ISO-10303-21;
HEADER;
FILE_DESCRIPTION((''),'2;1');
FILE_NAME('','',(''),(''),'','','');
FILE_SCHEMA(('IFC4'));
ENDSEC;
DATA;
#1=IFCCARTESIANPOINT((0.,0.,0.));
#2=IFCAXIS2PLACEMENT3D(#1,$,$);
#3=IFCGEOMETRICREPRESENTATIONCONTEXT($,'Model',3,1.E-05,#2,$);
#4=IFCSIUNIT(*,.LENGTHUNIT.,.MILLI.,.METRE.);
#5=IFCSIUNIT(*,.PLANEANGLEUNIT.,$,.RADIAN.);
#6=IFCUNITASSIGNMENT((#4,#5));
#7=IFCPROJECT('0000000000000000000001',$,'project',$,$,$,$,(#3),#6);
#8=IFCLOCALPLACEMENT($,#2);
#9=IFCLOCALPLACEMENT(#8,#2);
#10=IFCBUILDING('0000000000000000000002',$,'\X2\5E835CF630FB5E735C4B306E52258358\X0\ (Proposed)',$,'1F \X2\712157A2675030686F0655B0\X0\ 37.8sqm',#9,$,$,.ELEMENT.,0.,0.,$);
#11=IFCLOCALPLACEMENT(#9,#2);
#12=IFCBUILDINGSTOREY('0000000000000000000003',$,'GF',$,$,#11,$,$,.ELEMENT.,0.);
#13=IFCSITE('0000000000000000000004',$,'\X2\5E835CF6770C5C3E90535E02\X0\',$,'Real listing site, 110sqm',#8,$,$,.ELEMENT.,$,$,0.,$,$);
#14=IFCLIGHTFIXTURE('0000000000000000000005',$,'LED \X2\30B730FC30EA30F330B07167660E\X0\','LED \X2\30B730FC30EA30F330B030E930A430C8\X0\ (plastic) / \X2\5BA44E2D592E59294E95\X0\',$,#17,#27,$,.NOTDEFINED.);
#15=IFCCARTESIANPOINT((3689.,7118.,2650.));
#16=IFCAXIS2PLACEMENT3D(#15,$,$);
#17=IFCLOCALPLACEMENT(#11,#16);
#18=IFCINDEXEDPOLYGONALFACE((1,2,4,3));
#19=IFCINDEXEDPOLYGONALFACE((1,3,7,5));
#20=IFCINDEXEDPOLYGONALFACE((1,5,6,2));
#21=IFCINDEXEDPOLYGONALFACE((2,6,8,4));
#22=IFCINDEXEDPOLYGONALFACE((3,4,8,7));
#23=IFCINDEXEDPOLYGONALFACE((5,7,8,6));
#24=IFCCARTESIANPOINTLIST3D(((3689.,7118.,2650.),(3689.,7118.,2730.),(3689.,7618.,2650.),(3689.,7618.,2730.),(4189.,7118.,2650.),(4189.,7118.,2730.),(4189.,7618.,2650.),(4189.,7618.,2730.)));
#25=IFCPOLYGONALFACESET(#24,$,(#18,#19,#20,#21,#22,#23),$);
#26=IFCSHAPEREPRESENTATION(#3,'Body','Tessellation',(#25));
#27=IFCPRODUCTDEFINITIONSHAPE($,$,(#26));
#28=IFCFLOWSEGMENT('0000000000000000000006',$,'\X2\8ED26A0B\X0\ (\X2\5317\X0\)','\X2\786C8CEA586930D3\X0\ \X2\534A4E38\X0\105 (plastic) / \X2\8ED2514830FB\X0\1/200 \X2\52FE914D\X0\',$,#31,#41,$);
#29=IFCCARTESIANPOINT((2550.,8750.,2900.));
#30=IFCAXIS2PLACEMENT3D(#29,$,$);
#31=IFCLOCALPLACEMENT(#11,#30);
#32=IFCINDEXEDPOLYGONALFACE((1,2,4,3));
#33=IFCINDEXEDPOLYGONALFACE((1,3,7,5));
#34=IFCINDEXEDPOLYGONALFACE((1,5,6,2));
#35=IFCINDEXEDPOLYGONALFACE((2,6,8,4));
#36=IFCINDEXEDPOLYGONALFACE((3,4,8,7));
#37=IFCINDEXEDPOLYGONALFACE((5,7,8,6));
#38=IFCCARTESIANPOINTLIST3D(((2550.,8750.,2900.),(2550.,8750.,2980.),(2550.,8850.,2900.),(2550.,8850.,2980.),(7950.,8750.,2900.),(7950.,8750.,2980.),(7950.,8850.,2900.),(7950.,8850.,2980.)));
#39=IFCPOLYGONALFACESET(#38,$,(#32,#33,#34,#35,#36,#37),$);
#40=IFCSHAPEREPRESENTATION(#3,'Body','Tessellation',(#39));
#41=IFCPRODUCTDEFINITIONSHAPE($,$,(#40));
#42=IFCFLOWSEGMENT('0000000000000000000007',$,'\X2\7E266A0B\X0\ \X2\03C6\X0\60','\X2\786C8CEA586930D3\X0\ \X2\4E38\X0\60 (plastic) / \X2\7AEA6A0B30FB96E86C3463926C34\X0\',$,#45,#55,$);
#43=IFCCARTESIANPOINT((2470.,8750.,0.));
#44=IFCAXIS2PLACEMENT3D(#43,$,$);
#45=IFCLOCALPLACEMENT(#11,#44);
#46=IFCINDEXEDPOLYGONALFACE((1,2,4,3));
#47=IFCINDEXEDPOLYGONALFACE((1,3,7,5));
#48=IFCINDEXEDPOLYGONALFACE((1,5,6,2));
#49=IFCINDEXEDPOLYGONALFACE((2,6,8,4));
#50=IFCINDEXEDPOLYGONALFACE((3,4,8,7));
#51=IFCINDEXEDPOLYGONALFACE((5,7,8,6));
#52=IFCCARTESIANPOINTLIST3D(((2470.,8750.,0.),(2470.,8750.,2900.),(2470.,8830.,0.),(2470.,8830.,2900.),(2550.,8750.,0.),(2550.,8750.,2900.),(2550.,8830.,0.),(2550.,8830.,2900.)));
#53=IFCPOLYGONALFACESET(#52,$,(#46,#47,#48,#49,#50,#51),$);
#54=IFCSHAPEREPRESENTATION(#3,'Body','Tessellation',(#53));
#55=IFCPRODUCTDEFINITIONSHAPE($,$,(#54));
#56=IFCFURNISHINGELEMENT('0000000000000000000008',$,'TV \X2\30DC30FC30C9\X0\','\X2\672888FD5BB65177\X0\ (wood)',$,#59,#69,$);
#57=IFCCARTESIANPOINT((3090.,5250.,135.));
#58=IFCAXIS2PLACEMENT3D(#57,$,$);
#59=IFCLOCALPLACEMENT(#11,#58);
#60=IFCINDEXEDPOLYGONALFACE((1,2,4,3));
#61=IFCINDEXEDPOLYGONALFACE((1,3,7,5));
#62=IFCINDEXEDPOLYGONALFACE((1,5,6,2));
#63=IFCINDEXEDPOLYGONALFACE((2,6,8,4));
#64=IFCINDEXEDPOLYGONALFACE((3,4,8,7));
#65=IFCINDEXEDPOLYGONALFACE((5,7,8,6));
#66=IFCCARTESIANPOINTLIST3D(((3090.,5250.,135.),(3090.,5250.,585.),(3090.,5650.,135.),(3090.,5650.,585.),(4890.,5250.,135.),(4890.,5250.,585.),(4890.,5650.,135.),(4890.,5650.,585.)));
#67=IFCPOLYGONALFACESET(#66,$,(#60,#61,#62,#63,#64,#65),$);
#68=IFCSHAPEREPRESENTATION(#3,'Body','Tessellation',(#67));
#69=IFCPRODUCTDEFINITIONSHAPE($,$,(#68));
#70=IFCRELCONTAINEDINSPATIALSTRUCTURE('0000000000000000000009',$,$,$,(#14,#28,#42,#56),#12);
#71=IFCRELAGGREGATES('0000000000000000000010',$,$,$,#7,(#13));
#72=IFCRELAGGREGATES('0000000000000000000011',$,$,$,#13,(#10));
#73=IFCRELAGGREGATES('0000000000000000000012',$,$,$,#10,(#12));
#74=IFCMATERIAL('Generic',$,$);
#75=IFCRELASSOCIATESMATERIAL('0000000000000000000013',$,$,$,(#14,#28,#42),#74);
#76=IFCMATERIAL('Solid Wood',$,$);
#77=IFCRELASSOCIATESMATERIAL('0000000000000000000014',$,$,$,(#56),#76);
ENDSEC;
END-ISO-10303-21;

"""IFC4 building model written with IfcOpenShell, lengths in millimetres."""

from ifc_helpers import new_model, si_unit, frame, frame_2d, origin, place, context, project, spatial, rectangle, extrude, material, element, save


model = new_model("IFC4")

# Units and contexts
model_context = context("Model", 3, precision=1e-05, world=origin())
ifc_project = project(units=[si_unit("LENGTHUNIT", "METRE", prefix="MILLI"), si_unit("PLANEANGLEUNIT", "RADIAN")], contexts=[model_context])

# Site, building, storey
site_placement = place(None, origin())
site = spatial("IfcSite", under=ifc_project, at=site_placement, Name="広島県尾道市", ObjectType="Real listing site, 110sqm", CompositionType="ELEMENT", RefElevation=0.0)
building_placement = place(site_placement, origin())
building = spatial("IfcBuilding", under=site, at=building_placement, Name="広島・平屋の別荘 (Proposed)", ObjectType="1F 無垢材と漆喰 37.8sqm", CompositionType="ELEMENT", ElevationOfRefHeight=0.0, ElevationOfTerrain=0.0)
storey_placement = place(building_placement, origin())
storey = spatial("IfcBuildingStorey", under=building, at=storey_placement, Name="GF", CompositionType="ELEMENT", Elevation=0.0)

# Shared definitions
ifc_material_1 = material(Name="Solid Wood")

# Shared definitions
ifc_material_2 = material(Name="Generic")

# Light fixture
light_fixture_placement = place(storey_placement, frame((3689.0, 7118.0, 2650.0)))
element("IfcLightFixture", 1, at=light_fixture_placement, inside=storey, material=ifc_material_2, Name="LED シーリング照明", Description="LED シーリングライト (plastic) / 室中央天井", PredefinedType="NOTDEFINED", context=model_context, shape_type="SweptSolid", body=[
    extrude(rectangle(XDim=500.0, YDim=500.0, at=frame_2d((250.0, 250.0))), frame((3689.0, 7118.0, 2650.0)), (0.0, 0.0, 1.0), 80.0),
])

# Flow segments
flow_segment_1_placement = place(storey_placement, frame((2550.0, 8750.0, 2900.0)))
element("IfcFlowSegment", 2, at=flow_segment_1_placement, inside=storey, material=ifc_material_2, Name="軒樋 (北)", Description="硬質塩ビ 半丸105 (plastic) / 軒先・1/200 勾配", context=model_context, shape_type="SweptSolid", body=[
    extrude(rectangle(XDim=5400.0, YDim=100.0, at=frame_2d((2700.0, 50.0))), frame((2550.0, 8750.0, 2900.0)), (0.0, 0.0, 1.0), 80.0),
])
flow_segment_2_placement = place(storey_placement, frame((2470.0, 8750.0, 0.0)))
element("IfcFlowSegment", 3, at=flow_segment_2_placement, inside=storey, material=ifc_material_2, Name="縦樋 φ60", Description="硬質塩ビ 丸60 (plastic) / 竪樋・雨水排水", context=model_context, shape_type="SweptSolid", body=[
    extrude(rectangle(XDim=80.0, YDim=80.0, at=frame_2d((40.0, 40.0))), frame((2470.0, 8750.0, 0.0)), (0.0, 0.0, 1.0), 2900.0),
])

# Furnishing element
furnishing_placement = place(storey_placement, frame((3090.0, 5250.0, 135.0)))
element("IfcFurnishingElement", 4, at=furnishing_placement, inside=storey, material=ifc_material_1, Name="TV ボード", Description="木製家具 (wood)", context=model_context, shape_type="SweptSolid", body=[
    extrude(rectangle(XDim=1800.0, YDim=400.0, at=frame_2d((900.0, 200.0))), frame((3090.0, 5250.0, 135.0)), (0.0, 0.0, 1.0), 450.0),
])

save(model, "model.ifc")
